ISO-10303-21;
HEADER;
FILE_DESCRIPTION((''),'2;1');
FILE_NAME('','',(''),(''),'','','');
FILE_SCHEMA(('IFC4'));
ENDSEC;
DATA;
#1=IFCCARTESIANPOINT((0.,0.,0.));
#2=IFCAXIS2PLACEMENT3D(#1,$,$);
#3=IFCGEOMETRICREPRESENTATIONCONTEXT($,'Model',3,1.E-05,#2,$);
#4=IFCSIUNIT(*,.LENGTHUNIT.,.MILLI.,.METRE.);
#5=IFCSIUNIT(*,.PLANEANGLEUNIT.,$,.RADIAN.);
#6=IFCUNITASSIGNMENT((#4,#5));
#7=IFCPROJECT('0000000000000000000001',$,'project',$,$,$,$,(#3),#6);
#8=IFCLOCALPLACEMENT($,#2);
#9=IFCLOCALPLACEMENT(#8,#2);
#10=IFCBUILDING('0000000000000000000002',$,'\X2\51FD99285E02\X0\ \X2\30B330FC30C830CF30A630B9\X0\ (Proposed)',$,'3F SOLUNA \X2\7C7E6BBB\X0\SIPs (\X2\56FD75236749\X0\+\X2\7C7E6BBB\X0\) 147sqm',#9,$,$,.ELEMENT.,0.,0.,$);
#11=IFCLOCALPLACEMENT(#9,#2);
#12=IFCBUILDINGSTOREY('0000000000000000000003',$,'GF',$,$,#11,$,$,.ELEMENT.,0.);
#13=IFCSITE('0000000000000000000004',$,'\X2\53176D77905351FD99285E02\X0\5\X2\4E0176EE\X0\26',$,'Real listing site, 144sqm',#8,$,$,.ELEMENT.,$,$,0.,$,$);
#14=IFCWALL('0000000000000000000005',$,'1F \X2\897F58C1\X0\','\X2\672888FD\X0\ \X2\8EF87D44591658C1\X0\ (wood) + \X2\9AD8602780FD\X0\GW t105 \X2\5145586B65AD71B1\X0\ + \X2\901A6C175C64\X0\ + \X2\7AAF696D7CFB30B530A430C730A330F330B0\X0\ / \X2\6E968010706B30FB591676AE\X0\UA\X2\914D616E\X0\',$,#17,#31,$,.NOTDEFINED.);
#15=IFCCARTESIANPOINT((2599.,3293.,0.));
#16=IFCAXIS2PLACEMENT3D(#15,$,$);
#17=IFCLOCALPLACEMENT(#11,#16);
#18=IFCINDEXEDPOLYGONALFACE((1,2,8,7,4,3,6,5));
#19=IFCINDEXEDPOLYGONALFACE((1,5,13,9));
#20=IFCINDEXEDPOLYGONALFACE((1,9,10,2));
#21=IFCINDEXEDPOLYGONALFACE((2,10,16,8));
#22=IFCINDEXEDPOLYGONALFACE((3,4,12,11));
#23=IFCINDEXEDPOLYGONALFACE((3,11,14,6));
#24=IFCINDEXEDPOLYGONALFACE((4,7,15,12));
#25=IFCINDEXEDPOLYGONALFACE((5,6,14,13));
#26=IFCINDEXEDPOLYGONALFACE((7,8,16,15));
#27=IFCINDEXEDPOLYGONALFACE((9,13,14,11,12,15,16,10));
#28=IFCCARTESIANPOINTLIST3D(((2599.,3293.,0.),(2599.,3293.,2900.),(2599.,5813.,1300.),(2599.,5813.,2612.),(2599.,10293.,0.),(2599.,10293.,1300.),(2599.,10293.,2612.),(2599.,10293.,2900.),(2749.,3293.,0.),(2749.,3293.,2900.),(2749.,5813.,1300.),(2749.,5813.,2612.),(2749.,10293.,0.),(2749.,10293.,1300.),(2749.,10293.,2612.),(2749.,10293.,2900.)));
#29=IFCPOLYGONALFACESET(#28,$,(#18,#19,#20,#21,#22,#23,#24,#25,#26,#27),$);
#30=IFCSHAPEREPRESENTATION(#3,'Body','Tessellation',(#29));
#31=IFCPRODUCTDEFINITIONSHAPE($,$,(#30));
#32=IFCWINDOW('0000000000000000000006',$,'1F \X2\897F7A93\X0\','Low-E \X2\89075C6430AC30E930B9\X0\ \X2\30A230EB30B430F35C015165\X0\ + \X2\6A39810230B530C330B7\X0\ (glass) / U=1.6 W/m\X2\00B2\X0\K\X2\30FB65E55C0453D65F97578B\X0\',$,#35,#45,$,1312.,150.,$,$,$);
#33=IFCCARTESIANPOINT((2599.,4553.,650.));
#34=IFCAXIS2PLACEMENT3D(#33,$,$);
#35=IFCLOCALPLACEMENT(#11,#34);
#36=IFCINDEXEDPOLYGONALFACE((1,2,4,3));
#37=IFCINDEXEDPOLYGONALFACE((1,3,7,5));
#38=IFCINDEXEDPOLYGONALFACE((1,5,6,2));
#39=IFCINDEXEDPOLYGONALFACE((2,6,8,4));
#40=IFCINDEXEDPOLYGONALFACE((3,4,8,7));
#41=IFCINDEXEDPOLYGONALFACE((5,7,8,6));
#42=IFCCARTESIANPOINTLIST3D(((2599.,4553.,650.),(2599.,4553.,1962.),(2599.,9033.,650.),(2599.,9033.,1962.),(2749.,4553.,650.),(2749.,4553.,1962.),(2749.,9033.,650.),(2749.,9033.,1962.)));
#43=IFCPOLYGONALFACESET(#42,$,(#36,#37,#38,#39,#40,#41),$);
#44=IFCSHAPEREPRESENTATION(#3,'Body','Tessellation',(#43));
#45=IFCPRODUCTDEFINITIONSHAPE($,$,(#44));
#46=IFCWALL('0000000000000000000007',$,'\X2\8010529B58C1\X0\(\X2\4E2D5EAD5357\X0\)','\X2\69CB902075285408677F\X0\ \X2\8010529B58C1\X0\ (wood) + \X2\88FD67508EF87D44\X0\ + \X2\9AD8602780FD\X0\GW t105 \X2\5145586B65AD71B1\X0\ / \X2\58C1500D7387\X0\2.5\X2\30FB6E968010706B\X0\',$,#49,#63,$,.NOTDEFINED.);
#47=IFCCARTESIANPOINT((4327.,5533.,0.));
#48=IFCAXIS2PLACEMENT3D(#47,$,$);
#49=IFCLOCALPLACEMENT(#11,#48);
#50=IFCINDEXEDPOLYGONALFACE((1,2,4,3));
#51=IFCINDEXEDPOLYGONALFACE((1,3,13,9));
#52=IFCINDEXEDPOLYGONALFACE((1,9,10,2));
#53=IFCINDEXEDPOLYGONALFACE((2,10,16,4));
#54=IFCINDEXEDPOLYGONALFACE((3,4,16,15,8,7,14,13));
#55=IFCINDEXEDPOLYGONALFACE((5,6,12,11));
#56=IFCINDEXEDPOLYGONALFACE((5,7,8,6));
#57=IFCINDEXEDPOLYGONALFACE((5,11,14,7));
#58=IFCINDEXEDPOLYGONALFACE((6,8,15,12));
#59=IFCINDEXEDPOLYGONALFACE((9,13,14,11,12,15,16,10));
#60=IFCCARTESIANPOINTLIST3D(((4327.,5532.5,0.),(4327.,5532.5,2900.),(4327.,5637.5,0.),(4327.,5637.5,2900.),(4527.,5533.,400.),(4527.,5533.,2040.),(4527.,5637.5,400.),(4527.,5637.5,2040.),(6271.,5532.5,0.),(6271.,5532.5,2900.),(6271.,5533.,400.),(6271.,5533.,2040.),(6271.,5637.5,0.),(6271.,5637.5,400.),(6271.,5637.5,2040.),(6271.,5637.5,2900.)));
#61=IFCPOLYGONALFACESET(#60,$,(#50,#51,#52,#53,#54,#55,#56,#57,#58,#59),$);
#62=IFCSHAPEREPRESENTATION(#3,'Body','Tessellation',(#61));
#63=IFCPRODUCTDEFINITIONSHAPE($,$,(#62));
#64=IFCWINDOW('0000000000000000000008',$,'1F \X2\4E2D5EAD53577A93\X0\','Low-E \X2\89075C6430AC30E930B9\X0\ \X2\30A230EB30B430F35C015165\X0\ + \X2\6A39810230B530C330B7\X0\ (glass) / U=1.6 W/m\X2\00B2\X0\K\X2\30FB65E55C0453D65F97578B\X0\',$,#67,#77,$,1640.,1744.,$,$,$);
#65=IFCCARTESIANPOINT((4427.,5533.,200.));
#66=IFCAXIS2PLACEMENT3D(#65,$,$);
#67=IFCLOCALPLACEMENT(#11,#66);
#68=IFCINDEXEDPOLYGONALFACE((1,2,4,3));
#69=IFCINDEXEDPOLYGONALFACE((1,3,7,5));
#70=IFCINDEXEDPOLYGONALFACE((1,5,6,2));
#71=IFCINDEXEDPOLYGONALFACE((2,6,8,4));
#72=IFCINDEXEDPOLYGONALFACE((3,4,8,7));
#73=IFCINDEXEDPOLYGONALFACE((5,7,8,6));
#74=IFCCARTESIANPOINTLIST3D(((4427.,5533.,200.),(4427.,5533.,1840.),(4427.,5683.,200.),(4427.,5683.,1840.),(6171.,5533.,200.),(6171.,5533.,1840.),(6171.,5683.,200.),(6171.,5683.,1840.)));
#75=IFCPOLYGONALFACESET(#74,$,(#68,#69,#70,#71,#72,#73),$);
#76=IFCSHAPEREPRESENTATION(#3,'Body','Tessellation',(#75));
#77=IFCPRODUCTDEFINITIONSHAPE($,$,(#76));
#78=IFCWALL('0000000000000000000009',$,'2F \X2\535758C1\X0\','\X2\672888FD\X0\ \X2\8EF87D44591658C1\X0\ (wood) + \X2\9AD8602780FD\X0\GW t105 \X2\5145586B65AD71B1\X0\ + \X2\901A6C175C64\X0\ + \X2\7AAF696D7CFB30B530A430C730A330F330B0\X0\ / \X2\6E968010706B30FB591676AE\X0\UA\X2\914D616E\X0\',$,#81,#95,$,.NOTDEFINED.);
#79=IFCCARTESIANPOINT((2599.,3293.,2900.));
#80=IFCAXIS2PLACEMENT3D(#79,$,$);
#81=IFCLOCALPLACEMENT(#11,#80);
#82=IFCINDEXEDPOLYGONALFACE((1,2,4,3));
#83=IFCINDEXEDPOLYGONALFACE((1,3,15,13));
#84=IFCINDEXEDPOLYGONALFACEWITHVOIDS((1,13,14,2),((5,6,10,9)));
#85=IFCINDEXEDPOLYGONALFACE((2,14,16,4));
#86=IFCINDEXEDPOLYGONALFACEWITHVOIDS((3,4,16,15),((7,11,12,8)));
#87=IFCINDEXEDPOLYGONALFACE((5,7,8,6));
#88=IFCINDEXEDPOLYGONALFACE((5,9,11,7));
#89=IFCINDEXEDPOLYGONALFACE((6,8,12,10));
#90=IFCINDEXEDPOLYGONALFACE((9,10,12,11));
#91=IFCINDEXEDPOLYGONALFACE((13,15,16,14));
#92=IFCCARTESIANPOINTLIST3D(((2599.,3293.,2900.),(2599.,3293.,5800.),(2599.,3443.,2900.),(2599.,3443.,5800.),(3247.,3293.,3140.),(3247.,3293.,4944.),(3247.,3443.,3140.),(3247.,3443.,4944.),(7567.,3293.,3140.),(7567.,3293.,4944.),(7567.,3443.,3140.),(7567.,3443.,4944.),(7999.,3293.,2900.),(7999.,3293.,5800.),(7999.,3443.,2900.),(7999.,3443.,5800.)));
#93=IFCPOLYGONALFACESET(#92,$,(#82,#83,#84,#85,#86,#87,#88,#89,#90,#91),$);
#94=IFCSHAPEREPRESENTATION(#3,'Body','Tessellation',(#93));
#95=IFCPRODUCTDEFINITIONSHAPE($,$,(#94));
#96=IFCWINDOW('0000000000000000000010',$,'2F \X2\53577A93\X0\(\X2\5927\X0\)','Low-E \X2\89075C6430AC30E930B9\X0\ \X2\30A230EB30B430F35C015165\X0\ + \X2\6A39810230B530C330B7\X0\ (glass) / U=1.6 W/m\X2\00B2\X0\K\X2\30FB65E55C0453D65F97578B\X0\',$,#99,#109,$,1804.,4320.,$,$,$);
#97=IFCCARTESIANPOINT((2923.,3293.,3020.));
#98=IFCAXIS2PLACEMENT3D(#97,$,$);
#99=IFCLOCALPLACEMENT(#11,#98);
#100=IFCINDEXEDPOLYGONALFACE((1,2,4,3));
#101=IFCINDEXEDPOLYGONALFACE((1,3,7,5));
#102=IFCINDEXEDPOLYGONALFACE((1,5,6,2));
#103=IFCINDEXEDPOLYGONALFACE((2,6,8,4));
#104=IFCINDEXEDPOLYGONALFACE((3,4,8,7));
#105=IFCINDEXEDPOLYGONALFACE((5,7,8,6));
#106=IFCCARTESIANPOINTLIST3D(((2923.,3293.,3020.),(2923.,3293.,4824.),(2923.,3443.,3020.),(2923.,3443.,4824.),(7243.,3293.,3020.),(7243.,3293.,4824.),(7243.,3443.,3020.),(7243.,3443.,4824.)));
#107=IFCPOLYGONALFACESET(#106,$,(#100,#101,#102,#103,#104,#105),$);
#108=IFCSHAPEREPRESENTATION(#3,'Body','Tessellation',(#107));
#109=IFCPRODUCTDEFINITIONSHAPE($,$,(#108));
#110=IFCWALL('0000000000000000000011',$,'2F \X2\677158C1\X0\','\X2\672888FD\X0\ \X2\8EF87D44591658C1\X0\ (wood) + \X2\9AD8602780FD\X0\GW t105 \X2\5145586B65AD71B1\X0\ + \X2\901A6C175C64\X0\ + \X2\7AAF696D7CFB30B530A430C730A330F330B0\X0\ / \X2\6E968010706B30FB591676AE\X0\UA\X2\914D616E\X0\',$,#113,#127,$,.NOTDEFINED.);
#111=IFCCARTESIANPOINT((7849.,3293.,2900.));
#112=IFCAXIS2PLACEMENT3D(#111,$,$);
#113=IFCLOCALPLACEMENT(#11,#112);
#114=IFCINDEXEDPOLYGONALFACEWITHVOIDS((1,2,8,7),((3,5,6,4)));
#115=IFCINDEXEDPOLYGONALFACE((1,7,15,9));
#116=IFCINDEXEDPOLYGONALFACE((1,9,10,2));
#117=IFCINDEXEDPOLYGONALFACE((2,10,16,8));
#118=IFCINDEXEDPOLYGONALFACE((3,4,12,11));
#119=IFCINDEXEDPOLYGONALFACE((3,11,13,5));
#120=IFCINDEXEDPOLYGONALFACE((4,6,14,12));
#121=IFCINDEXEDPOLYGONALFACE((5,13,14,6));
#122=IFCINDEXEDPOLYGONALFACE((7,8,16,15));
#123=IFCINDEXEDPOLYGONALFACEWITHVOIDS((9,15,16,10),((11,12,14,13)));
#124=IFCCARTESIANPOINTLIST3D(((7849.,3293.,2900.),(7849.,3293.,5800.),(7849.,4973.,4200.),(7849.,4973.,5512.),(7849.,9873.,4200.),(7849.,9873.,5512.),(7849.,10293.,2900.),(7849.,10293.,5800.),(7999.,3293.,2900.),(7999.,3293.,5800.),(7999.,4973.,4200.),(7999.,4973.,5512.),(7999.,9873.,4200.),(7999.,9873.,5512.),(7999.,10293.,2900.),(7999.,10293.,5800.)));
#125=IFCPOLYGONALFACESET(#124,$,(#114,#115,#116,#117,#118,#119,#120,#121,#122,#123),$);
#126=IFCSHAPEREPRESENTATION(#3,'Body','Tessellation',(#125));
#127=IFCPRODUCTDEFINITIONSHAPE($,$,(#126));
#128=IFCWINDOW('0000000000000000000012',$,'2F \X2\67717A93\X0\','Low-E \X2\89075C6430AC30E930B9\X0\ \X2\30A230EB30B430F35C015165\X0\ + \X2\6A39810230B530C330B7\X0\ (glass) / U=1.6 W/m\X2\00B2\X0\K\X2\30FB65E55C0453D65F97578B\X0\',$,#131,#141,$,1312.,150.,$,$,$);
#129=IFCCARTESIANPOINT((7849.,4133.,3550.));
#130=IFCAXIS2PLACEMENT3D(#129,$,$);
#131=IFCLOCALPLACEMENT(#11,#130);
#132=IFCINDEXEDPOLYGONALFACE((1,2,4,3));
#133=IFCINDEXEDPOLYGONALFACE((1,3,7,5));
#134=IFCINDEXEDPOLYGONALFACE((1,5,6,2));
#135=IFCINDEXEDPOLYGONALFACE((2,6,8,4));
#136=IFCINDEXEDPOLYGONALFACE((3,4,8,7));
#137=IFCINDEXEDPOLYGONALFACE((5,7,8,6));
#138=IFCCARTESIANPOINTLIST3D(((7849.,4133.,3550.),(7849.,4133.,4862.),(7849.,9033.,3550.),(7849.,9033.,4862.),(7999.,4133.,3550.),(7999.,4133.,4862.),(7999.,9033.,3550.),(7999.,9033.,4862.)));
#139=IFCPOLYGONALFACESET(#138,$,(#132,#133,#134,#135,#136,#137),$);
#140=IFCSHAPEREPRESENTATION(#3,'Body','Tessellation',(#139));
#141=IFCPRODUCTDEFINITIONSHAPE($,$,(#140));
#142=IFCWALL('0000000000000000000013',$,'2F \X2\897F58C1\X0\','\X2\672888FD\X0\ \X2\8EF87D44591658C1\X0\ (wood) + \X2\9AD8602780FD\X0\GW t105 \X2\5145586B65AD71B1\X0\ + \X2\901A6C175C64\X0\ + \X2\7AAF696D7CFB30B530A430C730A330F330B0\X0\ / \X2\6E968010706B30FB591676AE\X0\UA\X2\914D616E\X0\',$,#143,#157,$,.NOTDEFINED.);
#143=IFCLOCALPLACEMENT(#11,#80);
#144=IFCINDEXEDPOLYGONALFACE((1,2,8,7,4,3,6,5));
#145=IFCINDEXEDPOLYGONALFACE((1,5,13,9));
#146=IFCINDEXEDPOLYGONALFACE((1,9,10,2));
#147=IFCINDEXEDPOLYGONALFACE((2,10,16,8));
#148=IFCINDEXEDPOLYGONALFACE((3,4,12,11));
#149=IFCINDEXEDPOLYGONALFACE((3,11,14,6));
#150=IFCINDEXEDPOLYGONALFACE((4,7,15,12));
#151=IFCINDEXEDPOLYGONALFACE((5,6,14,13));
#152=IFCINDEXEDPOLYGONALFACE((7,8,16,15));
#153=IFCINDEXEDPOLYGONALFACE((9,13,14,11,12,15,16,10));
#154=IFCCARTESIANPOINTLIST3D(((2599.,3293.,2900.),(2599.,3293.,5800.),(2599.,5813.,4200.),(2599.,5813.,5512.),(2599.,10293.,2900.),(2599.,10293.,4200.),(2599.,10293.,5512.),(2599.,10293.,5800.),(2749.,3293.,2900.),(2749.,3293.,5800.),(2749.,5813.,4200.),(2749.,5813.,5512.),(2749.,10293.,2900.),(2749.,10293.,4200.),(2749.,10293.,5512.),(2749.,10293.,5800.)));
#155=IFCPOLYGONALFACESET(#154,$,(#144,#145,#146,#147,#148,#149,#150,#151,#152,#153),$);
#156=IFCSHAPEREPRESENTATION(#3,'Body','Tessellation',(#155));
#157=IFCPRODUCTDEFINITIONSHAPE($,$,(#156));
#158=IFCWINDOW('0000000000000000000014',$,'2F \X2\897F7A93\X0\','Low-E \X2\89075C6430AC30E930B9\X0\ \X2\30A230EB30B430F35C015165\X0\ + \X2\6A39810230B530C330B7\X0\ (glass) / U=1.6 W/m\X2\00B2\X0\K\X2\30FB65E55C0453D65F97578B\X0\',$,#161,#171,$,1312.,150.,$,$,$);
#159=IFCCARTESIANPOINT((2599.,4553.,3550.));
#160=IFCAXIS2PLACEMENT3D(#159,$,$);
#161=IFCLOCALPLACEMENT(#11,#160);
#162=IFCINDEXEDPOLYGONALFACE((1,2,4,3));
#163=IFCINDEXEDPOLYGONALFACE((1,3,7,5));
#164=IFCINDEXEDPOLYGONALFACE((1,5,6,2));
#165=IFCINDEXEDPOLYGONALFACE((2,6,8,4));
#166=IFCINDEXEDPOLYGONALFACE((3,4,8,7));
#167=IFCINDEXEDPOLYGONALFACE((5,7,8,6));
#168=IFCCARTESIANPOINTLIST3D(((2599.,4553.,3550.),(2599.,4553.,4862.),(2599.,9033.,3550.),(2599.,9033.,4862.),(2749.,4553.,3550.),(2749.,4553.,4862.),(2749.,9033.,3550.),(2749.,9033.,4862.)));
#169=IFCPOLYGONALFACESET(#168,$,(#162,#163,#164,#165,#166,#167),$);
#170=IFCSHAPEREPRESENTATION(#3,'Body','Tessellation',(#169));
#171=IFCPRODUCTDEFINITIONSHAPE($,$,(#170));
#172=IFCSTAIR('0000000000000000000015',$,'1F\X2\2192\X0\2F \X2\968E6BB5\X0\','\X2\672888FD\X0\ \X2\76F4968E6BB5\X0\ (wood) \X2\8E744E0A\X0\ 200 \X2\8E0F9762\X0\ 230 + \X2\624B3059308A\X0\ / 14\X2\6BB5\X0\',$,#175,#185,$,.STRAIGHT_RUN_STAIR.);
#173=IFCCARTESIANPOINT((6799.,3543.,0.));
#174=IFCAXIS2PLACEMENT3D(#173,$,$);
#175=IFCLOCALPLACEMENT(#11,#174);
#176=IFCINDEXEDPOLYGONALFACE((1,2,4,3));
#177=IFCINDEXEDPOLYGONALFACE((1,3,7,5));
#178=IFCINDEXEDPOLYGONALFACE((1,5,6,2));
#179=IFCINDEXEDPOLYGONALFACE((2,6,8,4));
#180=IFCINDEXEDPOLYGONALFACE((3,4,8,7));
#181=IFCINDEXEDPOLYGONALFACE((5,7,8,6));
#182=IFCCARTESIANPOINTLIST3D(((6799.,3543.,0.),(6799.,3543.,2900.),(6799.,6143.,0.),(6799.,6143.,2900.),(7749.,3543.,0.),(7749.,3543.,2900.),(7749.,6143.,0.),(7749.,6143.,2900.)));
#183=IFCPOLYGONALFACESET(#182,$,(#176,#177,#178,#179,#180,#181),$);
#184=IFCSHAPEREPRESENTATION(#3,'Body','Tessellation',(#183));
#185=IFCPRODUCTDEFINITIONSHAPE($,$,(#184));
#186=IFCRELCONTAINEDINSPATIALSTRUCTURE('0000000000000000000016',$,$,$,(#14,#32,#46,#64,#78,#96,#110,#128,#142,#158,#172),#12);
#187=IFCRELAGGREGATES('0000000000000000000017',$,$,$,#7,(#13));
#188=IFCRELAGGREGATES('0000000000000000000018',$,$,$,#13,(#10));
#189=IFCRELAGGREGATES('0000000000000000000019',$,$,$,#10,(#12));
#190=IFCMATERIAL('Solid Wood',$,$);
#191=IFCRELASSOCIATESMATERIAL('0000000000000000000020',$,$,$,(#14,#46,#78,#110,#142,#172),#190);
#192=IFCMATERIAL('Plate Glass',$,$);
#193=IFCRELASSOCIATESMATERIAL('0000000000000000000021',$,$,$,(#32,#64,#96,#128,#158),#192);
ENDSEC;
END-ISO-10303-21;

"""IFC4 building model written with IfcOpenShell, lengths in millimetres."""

from ifc_helpers import new_model, si_unit, frame, frame_2d, origin, place, context, project, spatial, rectangle, extrude, material, element, fill, save


model = new_model("IFC4")

# Units and contexts
model_context = context("Model", 3, precision=1e-05, world=origin())
ifc_project = project(units=[si_unit("LENGTHUNIT", "METRE", prefix="MILLI"), si_unit("PLANEANGLEUNIT", "RADIAN")], contexts=[model_context])

# Site, building, storey
site_placement = place(None, origin())
site = spatial("IfcSite", under=ifc_project, at=site_placement, Name="北海道函館市5丁目26", ObjectType="Real listing site, 144sqm", CompositionType="ELEMENT", RefElevation=0.0)
building_placement = place(site_placement, origin())
building = spatial("IfcBuilding", under=site, at=building_placement, Name="函館市 コートハウス (Proposed)", ObjectType="3F SOLUNA 籾殻SIPs (国産杉+籾殻) 147sqm", CompositionType="ELEMENT", ElevationOfRefHeight=0.0, ElevationOfTerrain=0.0)
storey_placement = place(building_placement, origin())
storey = spatial("IfcBuildingStorey", under=building, at=storey_placement, Name="GF", CompositionType="ELEMENT", Elevation=0.0)

# Shared definitions
ifc_material_1 = material(Name="Solid Wood")

# Shared definitions
ifc_material_2 = material(Name="Plate Glass")

# Walls, openings, windows
wall_1_placement = place(storey_placement, frame((2599.0, 3293.0, 0.0)))
wall_1 = element("IfcWall", 1, at=wall_1_placement, inside=storey, material=ifc_material_1, Name="1F 西壁", Description="木製 軸組外壁 (wood) + 高性能GW t105 充填断熱 + 通気層 + 窯業系サイディング / 準耐火・外皮UA配慮", PredefinedType="NOTDEFINED", context=model_context, shape_type="SweptSolid", body=[
    extrude(rectangle(XDim=150.0, YDim=7000.0, at=frame_2d((75.0, 3500.0))), frame((2599.0, 3293.0, 0.0)), (0.0, 0.0, 1.0), 2900.0),
])
opening_1_placement = place(storey_placement, frame((2599.0, 4553.0, 650.0)))
opening_1 = element("IfcOpeningElement", 2, at=opening_1_placement, cuts=wall_1, PredefinedType="NOTDEFINED", context=model_context, shape_type="SweptSolid", body=[
    extrude(rectangle(XDim=150.0, YDim=4480.0, at=frame_2d((75.0, 2240.0))), frame((2599.0, 4553.0, 650.0)), (0.0, 0.0, 1.0), 1312.0),
])
window_1_placement = place(storey_placement, frame((2599.0, 4553.0, 650.0)))
window_1 = element("IfcWindow", 3, at=window_1_placement, inside=storey, material=ifc_material_2, Name="1F 西窓", Description="Low-E 複層ガラス アルゴン封入 + 樹脂サッシ (glass) / U=1.6 W/m²K・日射取得型", OverallHeight=1312.0, OverallWidth=150.0, context=model_context, shape_type="SweptSolid", body=[
    extrude(rectangle(XDim=150.0, YDim=4480.0, at=frame_2d((75.0, 2240.0))), frame((2599.0, 4553.0, 650.0)), (0.0, 0.0, 1.0), 1312.0),
])
fill(opening_1, window_1)
wall_2_placement = place(storey_placement, frame((4327.0, 5533.0, 0.0)))
wall_2 = element("IfcWall", 4, at=wall_2_placement, inside=storey, material=ifc_material_1, Name="耐力壁(中庭南)", Description="構造用合板 耐力壁 (wood) + 製材軸組 + 高性能GW t105 充填断熱 / 壁倍率2.5・準耐火", PredefinedType="NOTDEFINED", context=model_context, shape_type="SweptSolid", body=[
    extrude(rectangle(XDim=1944.0, YDim=105.0, at=frame_2d((972.0, 52.0))), frame((4327.0, 5533.0, 0.0)), (0.0, 0.0, 1.0), 2900.0),
])
opening_2_placement = place(storey_placement, frame((4427.0, 5533.0, 200.0)))
opening_2 = element("IfcOpeningElement", 5, at=opening_2_placement, cuts=wall_2, PredefinedType="NOTDEFINED", context=model_context, shape_type="SweptSolid", body=[
    extrude(rectangle(XDim=1744.0, YDim=150.0, at=frame_2d((872.0, 75.0))), frame((4427.0, 5533.0, 200.0)), (0.0, 0.0, 1.0), 1640.0),
])
window_2_placement = place(storey_placement, frame((4427.0, 5533.0, 200.0)))
window_2 = element("IfcWindow", 6, at=window_2_placement, inside=storey, material=ifc_material_2, Name="1F 中庭南窓", Description="Low-E 複層ガラス アルゴン封入 + 樹脂サッシ (glass) / U=1.6 W/m²K・日射取得型", OverallHeight=1640.0, OverallWidth=1744.0, context=model_context, shape_type="SweptSolid", body=[
    extrude(rectangle(XDim=1744.0, YDim=150.0, at=frame_2d((872.0, 75.0))), frame((4427.0, 5533.0, 200.0)), (0.0, 0.0, 1.0), 1640.0),
])
fill(opening_2, window_2)
wall_3_placement = place(storey_placement, frame((2599.0, 3293.0, 2900.0)))
wall_3 = element("IfcWall", 7, at=wall_3_placement, inside=storey, material=ifc_material_1, Name="2F 南壁", Description="木製 軸組外壁 (wood) + 高性能GW t105 充填断熱 + 通気層 + 窯業系サイディング / 準耐火・外皮UA配慮", PredefinedType="NOTDEFINED", context=model_context, shape_type="SweptSolid", body=[
    extrude(rectangle(XDim=5400.0, YDim=150.0, at=frame_2d((2700.0, 75.0))), frame((2599.0, 3293.0, 2900.0)), (0.0, 0.0, 1.0), 2900.0),
])
opening_3_placement = place(storey_placement, frame((2923.0, 3293.0, 3020.0)))
opening_3 = element("IfcOpeningElement", 8, at=opening_3_placement, cuts=wall_3, PredefinedType="NOTDEFINED", context=model_context, shape_type="SweptSolid", body=[
    extrude(rectangle(XDim=4320.0, YDim=150.0, at=frame_2d((2160.0, 75.0))), frame((2923.0, 3293.0, 3020.0)), (0.0, 0.0, 1.0), 1804.0),
])
window_3_placement = place(storey_placement, frame((2923.0, 3293.0, 3020.0)))
window_3 = element("IfcWindow", 9, at=window_3_placement, inside=storey, material=ifc_material_2, Name="2F 南窓(大)", Description="Low-E 複層ガラス アルゴン封入 + 樹脂サッシ (glass) / U=1.6 W/m²K・日射取得型", OverallHeight=1804.0, OverallWidth=4320.0, context=model_context, shape_type="SweptSolid", body=[
    extrude(rectangle(XDim=4320.0, YDim=150.0, at=frame_2d((2160.0, 75.0))), frame((2923.0, 3293.0, 3020.0)), (0.0, 0.0, 1.0), 1804.0),
])
fill(opening_3, window_3)
wall_4_placement = place(storey_placement, frame((7849.0, 3293.0, 2900.0)))
wall_4 = element("IfcWall", 10, at=wall_4_placement, inside=storey, material=ifc_material_1, Name="2F 東壁", Description="木製 軸組外壁 (wood) + 高性能GW t105 充填断熱 + 通気層 + 窯業系サイディング / 準耐火・外皮UA配慮", PredefinedType="NOTDEFINED", context=model_context, shape_type="SweptSolid", body=[
    extrude(rectangle(XDim=150.0, YDim=7000.0, at=frame_2d((75.0, 3500.0))), frame((7849.0, 3293.0, 2900.0)), (0.0, 0.0, 1.0), 2900.0),
])
opening_4_placement = place(storey_placement, frame((7849.0, 4133.0, 3550.0)))
opening_4 = element("IfcOpeningElement", 11, at=opening_4_placement, cuts=wall_4, PredefinedType="NOTDEFINED", context=model_context, shape_type="SweptSolid", body=[
    extrude(rectangle(XDim=150.0, YDim=4900.0, at=frame_2d((75.0, 2450.0))), frame((7849.0, 4133.0, 3550.0)), (0.0, 0.0, 1.0), 1312.0),
])
window_4_placement = place(storey_placement, frame((7849.0, 4133.0, 3550.0)))
window_4 = element("IfcWindow", 12, at=window_4_placement, inside=storey, material=ifc_material_2, Name="2F 東窓", Description="Low-E 複層ガラス アルゴン封入 + 樹脂サッシ (glass) / U=1.6 W/m²K・日射取得型", OverallHeight=1312.0, OverallWidth=150.0, context=model_context, shape_type="SweptSolid", body=[
    extrude(rectangle(XDim=150.0, YDim=4900.0, at=frame_2d((75.0, 2450.0))), frame((7849.0, 4133.0, 3550.0)), (0.0, 0.0, 1.0), 1312.0),
])
fill(opening_4, window_4)
wall_5_placement = place(storey_placement, frame((2599.0, 3293.0, 2900.0)))
wall_5 = element("IfcWall", 13, at=wall_5_placement, inside=storey, material=ifc_material_1, Name="2F 西壁", Description="木製 軸組外壁 (wood) + 高性能GW t105 充填断熱 + 通気層 + 窯業系サイディング / 準耐火・外皮UA配慮", PredefinedType="NOTDEFINED", context=model_context, shape_type="SweptSolid", body=[
    extrude(rectangle(XDim=150.0, YDim=7000.0, at=frame_2d((75.0, 3500.0))), frame((2599.0, 3293.0, 2900.0)), (0.0, 0.0, 1.0), 2900.0),
])
opening_5_placement = place(storey_placement, frame((2599.0, 4553.0, 3550.0)))
opening_5 = element("IfcOpeningElement", 14, at=opening_5_placement, cuts=wall_5, PredefinedType="NOTDEFINED", context=model_context, shape_type="SweptSolid", body=[
    extrude(rectangle(XDim=150.0, YDim=4480.0, at=frame_2d((75.0, 2240.0))), frame((2599.0, 4553.0, 3550.0)), (0.0, 0.0, 1.0), 1312.0),
])
window_5_placement = place(storey_placement, frame((2599.0, 4553.0, 3550.0)))
window_5 = element("IfcWindow", 15, at=window_5_placement, inside=storey, material=ifc_material_2, Name="2F 西窓", Description="Low-E 複層ガラス アルゴン封入 + 樹脂サッシ (glass) / U=1.6 W/m²K・日射取得型", OverallHeight=1312.0, OverallWidth=150.0, context=model_context, shape_type="SweptSolid", body=[
    extrude(rectangle(XDim=150.0, YDim=4480.0, at=frame_2d((75.0, 2240.0))), frame((2599.0, 4553.0, 3550.0)), (0.0, 0.0, 1.0), 1312.0),
])
fill(opening_5, window_5)

# Stair
stair_1_placement = place(storey_placement, frame((6799.0, 3543.0, 0.0)))
element("IfcStair", 16, at=stair_1_placement, inside=storey, material=ifc_material_1, Name="1F→2F 階段", Description="木製 直階段 (wood) 蹴上 200 踏面 230 + 手すり / 14段", PredefinedType="STRAIGHT_RUN_STAIR", context=model_context, shape_type="SweptSolid", body=[
    extrude(rectangle(XDim=950.0, YDim=2600.0, at=frame_2d((475.0, 1300.0))), frame((6799.0, 3543.0, 0.0)), (0.0, 0.0, 1.0), 2900.0),
])

save(model, "model.ifc")
